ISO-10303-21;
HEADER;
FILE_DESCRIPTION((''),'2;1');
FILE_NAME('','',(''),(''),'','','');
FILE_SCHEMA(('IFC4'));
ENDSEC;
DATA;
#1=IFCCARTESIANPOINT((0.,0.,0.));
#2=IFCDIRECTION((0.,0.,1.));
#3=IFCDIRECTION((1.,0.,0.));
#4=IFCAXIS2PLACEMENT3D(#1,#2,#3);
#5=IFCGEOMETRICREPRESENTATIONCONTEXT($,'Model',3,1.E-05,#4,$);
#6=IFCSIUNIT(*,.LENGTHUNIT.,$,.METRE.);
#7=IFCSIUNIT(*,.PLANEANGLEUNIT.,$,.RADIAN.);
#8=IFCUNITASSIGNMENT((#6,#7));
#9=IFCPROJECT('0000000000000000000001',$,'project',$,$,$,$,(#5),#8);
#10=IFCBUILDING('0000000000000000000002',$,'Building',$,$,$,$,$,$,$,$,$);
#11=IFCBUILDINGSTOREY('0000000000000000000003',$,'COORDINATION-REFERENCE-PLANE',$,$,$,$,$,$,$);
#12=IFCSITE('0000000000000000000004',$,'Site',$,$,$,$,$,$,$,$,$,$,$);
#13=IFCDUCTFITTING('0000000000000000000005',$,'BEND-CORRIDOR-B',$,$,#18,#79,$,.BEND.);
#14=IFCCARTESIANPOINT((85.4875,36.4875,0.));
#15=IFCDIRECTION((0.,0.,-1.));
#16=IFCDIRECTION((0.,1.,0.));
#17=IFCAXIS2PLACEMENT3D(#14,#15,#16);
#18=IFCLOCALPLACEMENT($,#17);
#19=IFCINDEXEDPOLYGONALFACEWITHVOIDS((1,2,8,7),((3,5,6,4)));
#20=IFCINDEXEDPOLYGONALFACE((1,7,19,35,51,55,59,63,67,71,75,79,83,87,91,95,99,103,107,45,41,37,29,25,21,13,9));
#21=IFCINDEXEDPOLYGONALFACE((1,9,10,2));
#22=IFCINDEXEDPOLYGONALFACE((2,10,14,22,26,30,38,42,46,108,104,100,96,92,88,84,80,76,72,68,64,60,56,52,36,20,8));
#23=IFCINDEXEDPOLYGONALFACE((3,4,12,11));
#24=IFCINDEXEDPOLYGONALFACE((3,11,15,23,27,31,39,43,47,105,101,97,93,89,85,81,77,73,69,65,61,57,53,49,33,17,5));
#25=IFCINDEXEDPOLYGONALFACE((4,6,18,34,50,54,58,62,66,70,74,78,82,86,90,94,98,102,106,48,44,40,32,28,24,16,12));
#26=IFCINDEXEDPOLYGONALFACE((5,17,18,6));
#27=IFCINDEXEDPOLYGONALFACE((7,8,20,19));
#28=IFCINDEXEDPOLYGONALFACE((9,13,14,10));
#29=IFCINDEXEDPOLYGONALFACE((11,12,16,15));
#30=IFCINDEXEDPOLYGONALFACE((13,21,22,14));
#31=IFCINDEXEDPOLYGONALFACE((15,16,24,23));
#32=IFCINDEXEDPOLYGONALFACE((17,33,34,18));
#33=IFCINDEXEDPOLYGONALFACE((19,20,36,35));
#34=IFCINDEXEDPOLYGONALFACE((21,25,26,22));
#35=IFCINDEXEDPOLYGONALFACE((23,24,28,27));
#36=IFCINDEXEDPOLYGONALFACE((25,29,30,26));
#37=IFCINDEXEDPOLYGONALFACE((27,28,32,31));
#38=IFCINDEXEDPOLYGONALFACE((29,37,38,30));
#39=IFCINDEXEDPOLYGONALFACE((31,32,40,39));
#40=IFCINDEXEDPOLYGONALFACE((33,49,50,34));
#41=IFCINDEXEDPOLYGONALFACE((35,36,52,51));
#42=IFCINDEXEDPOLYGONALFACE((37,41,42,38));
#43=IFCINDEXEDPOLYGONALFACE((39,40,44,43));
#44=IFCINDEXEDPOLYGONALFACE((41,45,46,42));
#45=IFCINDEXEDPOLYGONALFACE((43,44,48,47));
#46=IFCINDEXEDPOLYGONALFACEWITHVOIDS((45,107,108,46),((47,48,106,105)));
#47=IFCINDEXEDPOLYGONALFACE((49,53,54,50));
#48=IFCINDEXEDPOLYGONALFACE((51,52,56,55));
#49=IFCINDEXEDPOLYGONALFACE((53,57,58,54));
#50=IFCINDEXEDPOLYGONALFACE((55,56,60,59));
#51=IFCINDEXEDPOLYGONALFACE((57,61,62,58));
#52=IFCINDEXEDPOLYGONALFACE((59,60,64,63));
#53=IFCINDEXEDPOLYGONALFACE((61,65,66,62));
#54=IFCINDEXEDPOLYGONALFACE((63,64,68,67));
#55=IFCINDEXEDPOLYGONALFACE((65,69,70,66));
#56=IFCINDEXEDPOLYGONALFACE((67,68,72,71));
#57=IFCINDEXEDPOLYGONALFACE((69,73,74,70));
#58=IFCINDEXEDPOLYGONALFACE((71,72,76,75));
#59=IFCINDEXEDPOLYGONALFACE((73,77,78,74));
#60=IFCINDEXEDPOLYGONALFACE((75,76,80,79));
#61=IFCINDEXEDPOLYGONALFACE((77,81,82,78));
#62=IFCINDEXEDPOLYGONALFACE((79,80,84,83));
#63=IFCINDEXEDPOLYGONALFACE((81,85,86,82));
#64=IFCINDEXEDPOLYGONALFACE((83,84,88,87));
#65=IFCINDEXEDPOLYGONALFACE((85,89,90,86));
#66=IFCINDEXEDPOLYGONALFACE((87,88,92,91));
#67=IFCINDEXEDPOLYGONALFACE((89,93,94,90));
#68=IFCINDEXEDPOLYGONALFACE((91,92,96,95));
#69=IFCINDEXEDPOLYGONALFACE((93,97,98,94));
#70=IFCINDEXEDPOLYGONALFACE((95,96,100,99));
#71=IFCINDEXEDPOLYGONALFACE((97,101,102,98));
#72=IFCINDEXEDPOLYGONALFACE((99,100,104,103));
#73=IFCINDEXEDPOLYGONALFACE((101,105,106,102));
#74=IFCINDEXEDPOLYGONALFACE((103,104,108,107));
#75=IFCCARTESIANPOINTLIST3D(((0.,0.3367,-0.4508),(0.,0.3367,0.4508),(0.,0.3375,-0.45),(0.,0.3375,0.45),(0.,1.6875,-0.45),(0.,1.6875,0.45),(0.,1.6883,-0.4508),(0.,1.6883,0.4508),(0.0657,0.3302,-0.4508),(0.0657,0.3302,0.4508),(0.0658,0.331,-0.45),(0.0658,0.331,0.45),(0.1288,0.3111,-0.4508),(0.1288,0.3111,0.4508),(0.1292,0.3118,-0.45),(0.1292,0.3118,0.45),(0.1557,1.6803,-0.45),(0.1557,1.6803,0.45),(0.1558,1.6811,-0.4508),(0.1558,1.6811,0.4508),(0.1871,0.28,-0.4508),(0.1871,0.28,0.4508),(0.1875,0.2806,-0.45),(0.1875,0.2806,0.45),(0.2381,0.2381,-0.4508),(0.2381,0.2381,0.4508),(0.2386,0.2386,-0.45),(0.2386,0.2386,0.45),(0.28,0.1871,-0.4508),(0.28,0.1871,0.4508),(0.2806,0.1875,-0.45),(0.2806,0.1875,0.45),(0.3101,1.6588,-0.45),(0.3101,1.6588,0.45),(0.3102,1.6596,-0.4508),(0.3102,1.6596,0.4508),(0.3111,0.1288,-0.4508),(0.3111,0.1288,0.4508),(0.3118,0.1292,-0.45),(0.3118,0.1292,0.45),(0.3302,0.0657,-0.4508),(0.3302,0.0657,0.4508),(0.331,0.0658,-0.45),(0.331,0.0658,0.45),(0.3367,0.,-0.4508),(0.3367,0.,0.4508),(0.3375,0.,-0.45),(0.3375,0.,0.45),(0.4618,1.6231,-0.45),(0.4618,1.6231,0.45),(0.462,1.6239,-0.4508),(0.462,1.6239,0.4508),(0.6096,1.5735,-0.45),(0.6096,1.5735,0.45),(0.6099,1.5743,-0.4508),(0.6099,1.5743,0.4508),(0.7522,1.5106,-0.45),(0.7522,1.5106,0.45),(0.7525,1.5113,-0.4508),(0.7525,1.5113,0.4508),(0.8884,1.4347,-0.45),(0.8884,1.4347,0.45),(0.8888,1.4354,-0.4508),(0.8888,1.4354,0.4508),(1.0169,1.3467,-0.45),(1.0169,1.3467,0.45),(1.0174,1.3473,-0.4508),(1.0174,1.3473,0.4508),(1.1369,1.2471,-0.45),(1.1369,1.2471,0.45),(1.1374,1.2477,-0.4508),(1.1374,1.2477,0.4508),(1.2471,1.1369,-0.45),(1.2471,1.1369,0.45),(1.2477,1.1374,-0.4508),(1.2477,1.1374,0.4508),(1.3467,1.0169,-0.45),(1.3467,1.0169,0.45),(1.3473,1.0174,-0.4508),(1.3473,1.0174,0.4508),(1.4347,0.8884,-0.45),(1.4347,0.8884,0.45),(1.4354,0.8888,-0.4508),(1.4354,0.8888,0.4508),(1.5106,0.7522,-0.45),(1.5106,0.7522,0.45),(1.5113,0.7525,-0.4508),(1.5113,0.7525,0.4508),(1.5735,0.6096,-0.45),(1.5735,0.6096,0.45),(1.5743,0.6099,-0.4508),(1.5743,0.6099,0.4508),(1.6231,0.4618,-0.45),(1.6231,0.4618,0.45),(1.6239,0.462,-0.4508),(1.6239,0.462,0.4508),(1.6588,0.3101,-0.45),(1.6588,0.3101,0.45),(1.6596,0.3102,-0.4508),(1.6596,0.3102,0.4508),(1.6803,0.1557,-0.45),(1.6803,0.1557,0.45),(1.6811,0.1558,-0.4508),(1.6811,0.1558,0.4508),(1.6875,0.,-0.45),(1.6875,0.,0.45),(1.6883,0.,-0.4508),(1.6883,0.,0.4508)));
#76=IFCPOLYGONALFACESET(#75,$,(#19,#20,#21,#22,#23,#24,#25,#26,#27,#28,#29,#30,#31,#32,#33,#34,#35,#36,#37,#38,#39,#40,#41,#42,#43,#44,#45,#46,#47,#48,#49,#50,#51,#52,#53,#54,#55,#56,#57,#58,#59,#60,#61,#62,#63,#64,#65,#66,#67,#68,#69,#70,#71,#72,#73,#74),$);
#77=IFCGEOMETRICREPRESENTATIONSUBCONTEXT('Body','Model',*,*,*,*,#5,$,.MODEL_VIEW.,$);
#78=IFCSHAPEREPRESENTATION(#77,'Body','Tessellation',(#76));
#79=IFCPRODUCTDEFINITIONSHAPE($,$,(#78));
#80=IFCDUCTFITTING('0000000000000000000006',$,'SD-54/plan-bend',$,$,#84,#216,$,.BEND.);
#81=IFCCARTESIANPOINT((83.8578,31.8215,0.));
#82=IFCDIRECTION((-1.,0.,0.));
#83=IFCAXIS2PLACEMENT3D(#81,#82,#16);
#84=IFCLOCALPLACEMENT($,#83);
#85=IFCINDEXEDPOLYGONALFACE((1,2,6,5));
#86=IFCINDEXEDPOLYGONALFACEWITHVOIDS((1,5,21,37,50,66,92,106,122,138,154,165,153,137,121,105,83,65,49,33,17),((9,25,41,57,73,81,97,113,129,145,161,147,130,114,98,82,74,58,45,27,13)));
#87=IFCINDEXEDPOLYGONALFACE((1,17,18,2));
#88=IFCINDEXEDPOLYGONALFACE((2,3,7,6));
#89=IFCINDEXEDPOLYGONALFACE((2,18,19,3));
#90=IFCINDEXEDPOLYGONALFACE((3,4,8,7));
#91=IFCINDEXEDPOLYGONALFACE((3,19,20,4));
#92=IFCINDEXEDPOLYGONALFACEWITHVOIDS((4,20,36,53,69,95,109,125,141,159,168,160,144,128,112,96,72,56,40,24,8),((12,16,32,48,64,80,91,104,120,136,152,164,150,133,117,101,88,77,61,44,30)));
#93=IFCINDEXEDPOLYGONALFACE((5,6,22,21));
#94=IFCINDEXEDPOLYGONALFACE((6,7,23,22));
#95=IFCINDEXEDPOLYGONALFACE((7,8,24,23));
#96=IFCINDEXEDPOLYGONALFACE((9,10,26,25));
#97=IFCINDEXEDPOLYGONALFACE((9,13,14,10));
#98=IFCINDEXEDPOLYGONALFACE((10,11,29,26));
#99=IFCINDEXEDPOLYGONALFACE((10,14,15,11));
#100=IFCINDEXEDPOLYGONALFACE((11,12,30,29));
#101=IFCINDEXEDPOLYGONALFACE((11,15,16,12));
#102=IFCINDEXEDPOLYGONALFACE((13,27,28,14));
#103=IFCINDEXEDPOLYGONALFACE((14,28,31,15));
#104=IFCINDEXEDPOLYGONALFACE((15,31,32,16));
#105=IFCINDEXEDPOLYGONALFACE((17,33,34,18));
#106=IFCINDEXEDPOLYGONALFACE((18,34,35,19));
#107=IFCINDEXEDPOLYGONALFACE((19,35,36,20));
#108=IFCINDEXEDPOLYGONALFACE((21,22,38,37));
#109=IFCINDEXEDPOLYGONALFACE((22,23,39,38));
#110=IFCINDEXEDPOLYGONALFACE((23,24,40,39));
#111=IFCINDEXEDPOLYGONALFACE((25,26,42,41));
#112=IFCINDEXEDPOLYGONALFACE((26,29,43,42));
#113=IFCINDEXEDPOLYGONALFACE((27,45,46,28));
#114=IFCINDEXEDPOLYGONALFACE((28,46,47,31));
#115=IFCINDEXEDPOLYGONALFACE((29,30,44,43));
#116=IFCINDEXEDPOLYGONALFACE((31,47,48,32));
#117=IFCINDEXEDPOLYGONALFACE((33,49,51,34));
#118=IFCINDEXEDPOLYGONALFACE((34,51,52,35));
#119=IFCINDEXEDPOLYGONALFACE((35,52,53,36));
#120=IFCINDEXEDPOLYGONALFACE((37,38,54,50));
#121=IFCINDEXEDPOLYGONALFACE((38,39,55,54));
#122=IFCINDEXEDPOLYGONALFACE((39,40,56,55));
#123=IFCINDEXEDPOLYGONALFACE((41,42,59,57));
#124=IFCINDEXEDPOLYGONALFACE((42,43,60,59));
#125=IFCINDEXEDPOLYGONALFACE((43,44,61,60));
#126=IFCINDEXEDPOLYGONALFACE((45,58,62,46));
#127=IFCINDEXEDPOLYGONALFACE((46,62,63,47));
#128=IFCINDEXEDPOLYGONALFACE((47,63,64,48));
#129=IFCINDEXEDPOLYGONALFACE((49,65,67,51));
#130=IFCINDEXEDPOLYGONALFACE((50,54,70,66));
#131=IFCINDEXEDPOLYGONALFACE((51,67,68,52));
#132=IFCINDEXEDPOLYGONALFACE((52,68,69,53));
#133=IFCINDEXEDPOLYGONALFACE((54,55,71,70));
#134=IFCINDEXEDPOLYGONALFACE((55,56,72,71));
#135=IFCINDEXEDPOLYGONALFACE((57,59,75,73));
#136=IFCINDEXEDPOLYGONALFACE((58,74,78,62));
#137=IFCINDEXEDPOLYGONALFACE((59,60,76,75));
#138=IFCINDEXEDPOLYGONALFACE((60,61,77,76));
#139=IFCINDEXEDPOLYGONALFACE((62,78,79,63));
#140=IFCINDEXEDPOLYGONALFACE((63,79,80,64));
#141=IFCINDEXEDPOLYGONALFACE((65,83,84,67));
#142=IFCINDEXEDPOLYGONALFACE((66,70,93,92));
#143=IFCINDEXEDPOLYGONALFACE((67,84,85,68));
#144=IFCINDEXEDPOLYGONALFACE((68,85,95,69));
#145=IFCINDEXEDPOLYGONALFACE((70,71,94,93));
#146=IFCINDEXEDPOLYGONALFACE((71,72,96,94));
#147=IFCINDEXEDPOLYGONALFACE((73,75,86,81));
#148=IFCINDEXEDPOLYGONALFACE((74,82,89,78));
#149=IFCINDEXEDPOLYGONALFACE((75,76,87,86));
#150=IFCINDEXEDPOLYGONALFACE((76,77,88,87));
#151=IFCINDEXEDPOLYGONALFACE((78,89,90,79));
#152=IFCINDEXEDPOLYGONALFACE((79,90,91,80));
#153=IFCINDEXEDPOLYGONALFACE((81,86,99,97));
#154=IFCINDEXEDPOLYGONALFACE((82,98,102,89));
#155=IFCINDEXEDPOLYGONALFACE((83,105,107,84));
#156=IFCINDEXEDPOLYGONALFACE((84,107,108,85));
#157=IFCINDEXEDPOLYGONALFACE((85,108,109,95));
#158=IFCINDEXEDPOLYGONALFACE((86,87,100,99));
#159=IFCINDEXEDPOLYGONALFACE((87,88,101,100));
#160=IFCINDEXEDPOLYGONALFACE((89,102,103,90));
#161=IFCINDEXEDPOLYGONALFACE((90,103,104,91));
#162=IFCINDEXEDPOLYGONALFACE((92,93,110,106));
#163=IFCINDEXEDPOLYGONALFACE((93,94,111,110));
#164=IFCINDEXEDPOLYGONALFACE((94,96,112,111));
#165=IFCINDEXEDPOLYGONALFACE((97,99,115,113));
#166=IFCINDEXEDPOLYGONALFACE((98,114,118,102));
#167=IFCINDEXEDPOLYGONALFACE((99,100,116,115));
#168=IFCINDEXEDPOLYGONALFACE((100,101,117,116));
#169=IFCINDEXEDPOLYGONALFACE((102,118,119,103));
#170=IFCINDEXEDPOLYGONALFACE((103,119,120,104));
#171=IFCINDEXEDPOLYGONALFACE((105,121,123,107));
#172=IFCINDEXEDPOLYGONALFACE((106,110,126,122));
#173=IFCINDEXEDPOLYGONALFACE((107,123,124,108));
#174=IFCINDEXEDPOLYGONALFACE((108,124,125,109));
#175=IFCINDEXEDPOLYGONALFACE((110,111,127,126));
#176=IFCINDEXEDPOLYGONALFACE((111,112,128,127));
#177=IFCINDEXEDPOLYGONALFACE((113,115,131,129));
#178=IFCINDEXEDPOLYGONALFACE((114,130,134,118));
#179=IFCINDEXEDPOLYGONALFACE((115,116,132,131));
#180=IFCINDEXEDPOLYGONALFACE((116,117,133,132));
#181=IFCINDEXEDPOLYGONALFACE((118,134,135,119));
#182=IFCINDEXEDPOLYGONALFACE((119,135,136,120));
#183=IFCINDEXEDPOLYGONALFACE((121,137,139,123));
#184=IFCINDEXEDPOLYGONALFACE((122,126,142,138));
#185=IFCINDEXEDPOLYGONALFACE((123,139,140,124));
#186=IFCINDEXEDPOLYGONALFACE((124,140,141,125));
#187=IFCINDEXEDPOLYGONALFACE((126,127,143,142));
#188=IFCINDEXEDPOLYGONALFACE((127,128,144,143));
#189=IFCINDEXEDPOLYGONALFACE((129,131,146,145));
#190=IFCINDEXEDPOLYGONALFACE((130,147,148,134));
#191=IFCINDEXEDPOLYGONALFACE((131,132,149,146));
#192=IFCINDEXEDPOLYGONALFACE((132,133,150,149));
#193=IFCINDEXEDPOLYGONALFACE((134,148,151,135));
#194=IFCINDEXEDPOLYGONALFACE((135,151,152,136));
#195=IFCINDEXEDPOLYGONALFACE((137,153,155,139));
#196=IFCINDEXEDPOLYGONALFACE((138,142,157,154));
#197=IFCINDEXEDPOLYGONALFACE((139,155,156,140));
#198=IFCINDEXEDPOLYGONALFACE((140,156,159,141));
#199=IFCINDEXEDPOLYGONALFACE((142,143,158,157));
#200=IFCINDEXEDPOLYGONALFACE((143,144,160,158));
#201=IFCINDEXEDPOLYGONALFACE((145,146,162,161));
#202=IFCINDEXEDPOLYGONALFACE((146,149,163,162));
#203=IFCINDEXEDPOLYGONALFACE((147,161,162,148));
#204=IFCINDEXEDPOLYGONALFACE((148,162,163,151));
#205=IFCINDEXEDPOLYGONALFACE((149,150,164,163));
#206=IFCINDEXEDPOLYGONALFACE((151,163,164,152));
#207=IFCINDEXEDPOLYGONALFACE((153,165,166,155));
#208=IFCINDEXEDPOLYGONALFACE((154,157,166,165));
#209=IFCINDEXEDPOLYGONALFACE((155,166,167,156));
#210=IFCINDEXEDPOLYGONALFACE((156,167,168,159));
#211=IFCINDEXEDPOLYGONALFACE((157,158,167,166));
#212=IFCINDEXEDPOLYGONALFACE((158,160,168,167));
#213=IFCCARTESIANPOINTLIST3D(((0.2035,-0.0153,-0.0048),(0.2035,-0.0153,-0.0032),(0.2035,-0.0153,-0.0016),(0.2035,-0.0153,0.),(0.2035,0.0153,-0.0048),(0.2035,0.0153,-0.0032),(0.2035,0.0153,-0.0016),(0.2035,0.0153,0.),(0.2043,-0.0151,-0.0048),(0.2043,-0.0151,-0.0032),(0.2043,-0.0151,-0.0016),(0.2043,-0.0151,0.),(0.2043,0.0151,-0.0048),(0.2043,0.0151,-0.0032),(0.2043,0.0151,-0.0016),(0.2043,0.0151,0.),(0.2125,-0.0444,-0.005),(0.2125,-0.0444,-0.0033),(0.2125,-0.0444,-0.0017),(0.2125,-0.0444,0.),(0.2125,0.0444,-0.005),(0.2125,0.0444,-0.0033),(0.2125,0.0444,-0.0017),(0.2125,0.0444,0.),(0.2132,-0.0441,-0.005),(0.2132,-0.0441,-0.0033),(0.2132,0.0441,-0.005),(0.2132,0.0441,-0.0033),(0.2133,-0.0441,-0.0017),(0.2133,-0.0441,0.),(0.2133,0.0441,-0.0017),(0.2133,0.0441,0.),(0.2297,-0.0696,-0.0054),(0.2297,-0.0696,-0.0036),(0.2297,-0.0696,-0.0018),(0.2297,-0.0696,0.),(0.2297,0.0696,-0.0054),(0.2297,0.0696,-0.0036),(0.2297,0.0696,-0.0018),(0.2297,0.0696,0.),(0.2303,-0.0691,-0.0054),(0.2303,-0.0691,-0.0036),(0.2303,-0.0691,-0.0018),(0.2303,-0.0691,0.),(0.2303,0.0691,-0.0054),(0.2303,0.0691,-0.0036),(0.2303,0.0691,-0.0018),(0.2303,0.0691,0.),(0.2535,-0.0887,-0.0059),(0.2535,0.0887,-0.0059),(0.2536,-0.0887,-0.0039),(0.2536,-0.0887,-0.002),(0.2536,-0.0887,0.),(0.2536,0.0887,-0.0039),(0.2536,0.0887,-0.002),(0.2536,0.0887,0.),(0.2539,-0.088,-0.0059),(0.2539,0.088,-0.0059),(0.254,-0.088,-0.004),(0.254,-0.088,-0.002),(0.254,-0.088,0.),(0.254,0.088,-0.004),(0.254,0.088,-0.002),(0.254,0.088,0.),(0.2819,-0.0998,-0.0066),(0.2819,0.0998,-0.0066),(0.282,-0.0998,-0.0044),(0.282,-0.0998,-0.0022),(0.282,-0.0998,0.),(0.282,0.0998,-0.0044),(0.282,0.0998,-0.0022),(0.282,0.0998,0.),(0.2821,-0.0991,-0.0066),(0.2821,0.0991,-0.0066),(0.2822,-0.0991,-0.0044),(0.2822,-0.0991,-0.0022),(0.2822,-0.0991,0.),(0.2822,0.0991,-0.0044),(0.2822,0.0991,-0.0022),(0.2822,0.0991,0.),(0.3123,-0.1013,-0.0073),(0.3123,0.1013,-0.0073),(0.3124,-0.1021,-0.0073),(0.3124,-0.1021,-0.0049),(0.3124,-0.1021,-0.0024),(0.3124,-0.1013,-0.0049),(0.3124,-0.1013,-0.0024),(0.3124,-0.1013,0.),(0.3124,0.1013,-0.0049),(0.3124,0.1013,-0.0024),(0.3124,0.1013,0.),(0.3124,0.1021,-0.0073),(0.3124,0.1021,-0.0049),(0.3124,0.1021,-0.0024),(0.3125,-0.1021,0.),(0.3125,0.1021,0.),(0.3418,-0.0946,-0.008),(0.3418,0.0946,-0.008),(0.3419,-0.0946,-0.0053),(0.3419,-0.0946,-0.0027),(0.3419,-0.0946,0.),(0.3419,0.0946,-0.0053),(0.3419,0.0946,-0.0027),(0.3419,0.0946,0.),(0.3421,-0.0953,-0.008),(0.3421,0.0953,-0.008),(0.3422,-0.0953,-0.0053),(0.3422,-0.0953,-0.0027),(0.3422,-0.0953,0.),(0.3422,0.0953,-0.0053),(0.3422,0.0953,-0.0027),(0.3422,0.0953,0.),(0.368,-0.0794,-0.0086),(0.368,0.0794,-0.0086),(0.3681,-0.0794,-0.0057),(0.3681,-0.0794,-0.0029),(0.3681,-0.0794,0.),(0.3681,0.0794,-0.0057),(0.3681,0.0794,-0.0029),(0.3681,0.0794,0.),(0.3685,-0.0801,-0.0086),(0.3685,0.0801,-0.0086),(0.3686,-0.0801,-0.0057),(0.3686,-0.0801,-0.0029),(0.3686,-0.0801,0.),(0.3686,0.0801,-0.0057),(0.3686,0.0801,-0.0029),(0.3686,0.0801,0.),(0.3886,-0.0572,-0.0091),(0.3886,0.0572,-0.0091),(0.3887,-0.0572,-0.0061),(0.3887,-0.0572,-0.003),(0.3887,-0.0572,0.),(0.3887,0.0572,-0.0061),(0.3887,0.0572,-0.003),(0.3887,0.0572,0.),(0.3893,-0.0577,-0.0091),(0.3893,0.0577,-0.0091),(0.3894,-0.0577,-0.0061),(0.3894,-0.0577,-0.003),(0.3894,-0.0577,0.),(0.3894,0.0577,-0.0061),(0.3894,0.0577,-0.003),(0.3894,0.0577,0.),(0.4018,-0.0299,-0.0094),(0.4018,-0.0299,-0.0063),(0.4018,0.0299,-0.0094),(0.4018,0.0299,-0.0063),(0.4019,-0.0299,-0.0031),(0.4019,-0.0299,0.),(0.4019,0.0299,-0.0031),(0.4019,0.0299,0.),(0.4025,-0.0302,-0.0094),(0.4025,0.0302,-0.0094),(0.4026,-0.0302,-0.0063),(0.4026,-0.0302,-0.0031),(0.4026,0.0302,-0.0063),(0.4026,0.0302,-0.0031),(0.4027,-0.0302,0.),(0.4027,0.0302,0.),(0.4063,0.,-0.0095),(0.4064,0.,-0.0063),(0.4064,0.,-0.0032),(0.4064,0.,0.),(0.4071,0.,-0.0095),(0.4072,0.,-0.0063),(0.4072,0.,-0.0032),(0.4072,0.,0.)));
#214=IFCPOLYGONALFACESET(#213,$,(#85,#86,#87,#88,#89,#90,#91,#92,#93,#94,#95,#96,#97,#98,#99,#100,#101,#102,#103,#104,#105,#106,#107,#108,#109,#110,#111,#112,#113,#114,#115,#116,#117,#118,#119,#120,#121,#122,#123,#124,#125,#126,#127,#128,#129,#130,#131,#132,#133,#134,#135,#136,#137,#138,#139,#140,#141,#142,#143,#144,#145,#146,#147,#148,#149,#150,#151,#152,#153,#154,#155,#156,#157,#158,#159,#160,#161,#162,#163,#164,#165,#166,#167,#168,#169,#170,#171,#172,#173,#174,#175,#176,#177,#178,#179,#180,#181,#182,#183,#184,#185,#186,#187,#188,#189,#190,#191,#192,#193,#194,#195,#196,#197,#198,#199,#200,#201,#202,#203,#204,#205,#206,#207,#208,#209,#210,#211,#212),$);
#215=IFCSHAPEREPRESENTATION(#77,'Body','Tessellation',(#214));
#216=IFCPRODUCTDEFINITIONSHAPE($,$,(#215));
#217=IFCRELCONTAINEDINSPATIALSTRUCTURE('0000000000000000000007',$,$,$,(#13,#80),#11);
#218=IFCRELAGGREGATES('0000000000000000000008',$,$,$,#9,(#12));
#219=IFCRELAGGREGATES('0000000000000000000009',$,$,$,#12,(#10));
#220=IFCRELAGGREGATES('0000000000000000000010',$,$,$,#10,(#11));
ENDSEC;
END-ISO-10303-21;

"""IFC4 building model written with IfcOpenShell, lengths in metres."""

from ifc_helpers import new_model, entity, si_unit, frame, origin_with_axes, place, context, subcontext, project, spatial, element, save


model = new_model("IFC4")

# Units and contexts
model_context = context("Model", 3, precision=1e-05, world=origin_with_axes())
body_context = subcontext(model_context, "Body", "Model", "MODEL_VIEW")
ifc_project = project(units=[si_unit("LENGTHUNIT", "METRE"), si_unit("PLANEANGLEUNIT", "RADIAN")], contexts=[model_context])

# Site, building, storey
site = spatial("IfcSite", under=ifc_project, Name="Site")
building = spatial("IfcBuilding", under=site, Name="Building")
storey = spatial("IfcBuildingStorey", under=building, Name="COORDINATION-REFERENCE-PLANE")

# Duct fitting
duct_fitting_1_placement = place(None, frame((85.4875, 36.4875, 0.0), z_axis=(0.0, 0.0, -1.0), x_axis=(0.0, 1.0, 0.0)))
cartesian_point_1 = entity("IfcCartesianPoint", [0.0, 0.0, 0.0])
element("IfcDuctFitting", 1, at=duct_fitting_1_placement, inside=storey, Name="BEND-CORRIDOR-B", PredefinedType="BEND", context=body_context, shape_type="SweptSolid", body=[
    entity("IfcRevolvedAreaSolid", entity("IfcRectangleHollowProfileDef", "AREA", None, entity("IfcAxis2Placement2D", entity("IfcCartesianPoint", [1.0125, 0.0])), 1.3516, 0.9016, 0.0008), entity("IfcAxis2Placement3D", cartesian_point_1, entity("IfcDirection", [0.0, -1.0, 0.0]), entity("IfcDirection", [1.0, 0.0, 0.0])), entity("IfcAxis1Placement", cartesian_point_1, entity("IfcDirection", [0.0, 1.0, 0.0])), 1.570796),
])

# Duct fitting
duct_fitting_2_placement = place(None, frame((83.8578, 31.8215, 0.0), z_axis=(-1.0, 0.0, 0.0), x_axis=(0.0, 1.0, 0.0)))
element("IfcDuctFitting", 2, at=duct_fitting_2_placement, inside=storey, Name="SD-54/plan-bend", PredefinedType="BEND", context=body_context, shape_type="SweptSolid", body=[
    entity("IfcRevolvedAreaSolid", entity("IfcCircleHollowProfileDef", "AREA", None, entity("IfcAxis2Placement2D", entity("IfcCartesianPoint", [0.3048, 0.0])), 0.1024, 0.0008), entity("IfcAxis2Placement3D", entity("IfcCartesianPoint", [0.0, 0.0, 0.0]), entity("IfcDirection", [0.0, 0.0, 1.0]), entity("IfcDirection", [1.0, 0.0, 0.0])), entity("IfcAxis1Placement", entity("IfcCartesianPoint", [0.0, 0.0, 0.0]), entity("IfcDirection", [0.0, 1.0, 0.0])), 0.023363),
])

save(model, "model.ifc")
